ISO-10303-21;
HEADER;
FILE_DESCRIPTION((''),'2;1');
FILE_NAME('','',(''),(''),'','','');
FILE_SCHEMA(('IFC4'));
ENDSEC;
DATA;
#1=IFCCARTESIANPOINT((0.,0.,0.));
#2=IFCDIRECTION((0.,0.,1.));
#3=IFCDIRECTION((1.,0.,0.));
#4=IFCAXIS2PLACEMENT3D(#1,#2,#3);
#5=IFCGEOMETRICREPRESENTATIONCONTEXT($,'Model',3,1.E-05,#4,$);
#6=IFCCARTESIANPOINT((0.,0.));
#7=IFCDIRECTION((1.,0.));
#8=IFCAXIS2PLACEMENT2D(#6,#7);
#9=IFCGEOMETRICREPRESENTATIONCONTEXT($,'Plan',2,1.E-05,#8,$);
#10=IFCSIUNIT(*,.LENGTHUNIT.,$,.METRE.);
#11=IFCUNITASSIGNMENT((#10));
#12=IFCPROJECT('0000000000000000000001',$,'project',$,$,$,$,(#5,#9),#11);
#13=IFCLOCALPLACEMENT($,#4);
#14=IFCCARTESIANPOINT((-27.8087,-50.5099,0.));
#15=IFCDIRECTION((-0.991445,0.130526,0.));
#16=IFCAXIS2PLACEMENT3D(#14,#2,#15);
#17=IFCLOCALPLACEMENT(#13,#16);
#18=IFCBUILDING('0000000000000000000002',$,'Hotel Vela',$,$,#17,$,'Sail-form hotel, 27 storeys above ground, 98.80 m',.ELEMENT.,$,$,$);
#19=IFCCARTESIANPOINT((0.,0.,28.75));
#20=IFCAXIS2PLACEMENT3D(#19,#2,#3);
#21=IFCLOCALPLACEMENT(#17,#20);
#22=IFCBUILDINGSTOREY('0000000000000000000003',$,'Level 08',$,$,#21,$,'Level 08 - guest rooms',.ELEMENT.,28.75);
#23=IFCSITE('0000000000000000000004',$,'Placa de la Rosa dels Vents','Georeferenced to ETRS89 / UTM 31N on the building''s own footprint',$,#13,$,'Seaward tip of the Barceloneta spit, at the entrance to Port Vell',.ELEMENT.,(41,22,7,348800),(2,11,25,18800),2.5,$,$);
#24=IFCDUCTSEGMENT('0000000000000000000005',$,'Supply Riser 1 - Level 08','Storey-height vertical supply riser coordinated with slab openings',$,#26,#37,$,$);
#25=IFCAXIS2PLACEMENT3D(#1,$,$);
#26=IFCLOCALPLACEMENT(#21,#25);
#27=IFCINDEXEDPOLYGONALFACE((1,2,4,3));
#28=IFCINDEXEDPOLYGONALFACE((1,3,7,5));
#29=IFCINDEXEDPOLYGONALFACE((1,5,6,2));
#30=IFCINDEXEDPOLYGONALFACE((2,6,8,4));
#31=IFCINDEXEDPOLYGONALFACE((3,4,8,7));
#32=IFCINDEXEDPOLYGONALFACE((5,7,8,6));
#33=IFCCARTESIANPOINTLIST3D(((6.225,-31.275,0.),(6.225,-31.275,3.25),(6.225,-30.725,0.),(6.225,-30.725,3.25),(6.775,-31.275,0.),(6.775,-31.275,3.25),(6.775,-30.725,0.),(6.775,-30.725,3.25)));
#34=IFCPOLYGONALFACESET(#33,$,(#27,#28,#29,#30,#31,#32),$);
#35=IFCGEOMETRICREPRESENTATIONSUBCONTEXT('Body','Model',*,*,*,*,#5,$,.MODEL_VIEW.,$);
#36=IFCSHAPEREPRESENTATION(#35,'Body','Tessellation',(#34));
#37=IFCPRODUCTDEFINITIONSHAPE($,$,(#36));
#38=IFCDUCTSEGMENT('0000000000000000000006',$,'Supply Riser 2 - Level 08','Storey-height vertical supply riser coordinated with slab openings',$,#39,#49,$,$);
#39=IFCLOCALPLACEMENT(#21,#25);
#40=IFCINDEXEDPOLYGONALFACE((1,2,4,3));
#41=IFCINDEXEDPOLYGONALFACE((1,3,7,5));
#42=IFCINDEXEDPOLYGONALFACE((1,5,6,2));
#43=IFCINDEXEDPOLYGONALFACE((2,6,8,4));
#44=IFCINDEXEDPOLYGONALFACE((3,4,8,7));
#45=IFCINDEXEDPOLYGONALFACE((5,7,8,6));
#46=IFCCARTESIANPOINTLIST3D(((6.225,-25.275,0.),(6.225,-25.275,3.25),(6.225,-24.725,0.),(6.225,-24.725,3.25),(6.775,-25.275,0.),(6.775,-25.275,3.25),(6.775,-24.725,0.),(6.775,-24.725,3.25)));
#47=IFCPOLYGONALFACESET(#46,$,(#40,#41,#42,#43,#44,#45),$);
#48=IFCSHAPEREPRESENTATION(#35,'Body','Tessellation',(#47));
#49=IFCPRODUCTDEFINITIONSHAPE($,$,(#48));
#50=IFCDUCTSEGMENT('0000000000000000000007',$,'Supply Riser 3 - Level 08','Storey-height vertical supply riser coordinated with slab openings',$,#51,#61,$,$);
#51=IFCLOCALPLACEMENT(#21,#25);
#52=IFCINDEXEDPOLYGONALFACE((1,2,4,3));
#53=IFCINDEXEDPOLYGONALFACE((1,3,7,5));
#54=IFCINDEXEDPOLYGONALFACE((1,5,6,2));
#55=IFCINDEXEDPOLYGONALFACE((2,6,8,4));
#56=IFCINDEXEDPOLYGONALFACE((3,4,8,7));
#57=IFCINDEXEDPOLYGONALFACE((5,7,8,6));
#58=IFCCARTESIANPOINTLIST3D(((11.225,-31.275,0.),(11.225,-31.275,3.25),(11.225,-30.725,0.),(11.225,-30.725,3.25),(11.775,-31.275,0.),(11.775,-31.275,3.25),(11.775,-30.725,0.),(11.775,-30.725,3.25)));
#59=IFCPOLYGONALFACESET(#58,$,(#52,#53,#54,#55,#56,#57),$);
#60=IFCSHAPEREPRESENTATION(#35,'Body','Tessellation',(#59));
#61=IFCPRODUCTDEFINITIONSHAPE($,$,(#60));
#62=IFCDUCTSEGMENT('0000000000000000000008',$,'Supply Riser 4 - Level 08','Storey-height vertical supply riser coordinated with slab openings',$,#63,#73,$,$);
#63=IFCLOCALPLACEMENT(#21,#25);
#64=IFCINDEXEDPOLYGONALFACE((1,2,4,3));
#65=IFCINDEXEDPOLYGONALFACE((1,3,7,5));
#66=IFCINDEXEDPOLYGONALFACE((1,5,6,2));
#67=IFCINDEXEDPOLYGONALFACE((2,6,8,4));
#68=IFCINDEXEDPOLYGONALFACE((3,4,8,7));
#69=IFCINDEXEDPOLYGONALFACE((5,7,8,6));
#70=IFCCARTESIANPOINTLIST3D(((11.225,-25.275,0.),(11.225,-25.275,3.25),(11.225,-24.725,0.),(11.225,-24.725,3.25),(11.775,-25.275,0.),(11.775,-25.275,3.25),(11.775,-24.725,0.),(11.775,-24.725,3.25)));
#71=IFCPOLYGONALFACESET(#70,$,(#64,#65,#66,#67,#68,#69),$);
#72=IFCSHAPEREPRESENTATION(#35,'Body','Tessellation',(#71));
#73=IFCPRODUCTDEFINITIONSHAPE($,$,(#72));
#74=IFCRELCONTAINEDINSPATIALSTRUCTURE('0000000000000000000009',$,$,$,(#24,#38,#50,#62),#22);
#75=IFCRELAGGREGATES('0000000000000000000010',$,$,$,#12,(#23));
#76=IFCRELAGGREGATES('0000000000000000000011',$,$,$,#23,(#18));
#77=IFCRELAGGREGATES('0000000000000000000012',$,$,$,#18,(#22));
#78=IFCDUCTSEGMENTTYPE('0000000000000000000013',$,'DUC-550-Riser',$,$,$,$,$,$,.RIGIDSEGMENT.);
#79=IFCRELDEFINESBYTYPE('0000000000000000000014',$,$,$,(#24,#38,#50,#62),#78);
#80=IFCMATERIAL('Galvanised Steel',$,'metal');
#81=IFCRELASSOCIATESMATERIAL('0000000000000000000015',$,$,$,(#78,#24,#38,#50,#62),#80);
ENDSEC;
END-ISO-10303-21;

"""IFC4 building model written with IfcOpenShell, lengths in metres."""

from ifc_helpers import new_model, si_unit, frame, origin_with_axes, origin_2d_with_axis, place, context, subcontext, project, spatial, line, indexed_curve, outline, extrude, material, type_object, element, save


model = new_model("IFC4")

# Units and contexts
model_context = context("Model", 3, precision=1e-05, world=origin_with_axes())
plan_context = context("Plan", 2, precision=1e-05, world=origin_2d_with_axis())
body_context = subcontext(model_context, "Body", "Model", "MODEL_VIEW")
ifc_project = project(units=[si_unit("LENGTHUNIT", "METRE")], contexts=[model_context, plan_context])

# Site, building, storey
site_placement = place(None, origin_with_axes())
site = spatial("IfcSite", under=ifc_project, at=site_placement, Name="Placa de la Rosa dels Vents", Description="Georeferenced to ETRS89 / UTM 31N on the building's own footprint", LongName="Seaward tip of the Barceloneta spit, at the entrance to Port Vell", CompositionType="ELEMENT", RefLatitude=(41, 22, 7, 348800), RefLongitude=(2, 11, 25, 18800), RefElevation=2.5)
building_placement = place(site_placement, frame((-27.8087, -50.5099, 0.0), z_axis=(0.0, 0.0, 1.0), x_axis=(-0.991445, 0.130526, 0.0)))
building = spatial("IfcBuilding", under=site, at=building_placement, Name="Hotel Vela", LongName="Sail-form hotel, 27 storeys above ground, 98.80 m", CompositionType="ELEMENT")
storey_placement = place(building_placement, frame((0.0, 0.0, 28.75), z_axis=(0.0, 0.0, 1.0), x_axis=(1.0, 0.0, 0.0)))
storey = spatial("IfcBuildingStorey", under=building, at=storey_placement, Name="Level 08", LongName="Level 08 - guest rooms", CompositionType="ELEMENT", Elevation=28.75)

# Duct segments
ifc_material = material(Name="Galvanised Steel", Category="metal")
duct_segment_type = type_object("IfcDuctSegmentType", Name="DUC-550-Riser", PredefinedType="RIGIDSEGMENT", material=ifc_material)
for number, where, z_axis, x_axis, name in (
    (1, (6.225, -31.275, 0.0), (0.0, 0.0, 1.0), (1.0, 0.0, 0.0), "Supply Riser 1 - Level 08"),
    (2, (6.225, -25.275, 0.0), (0.0, 0.0, 1.0), (1.0, 0.0, 0.0), "Supply Riser 2 - Level 08"),
    (3, (11.225, -31.275, 0.0), (0.0, 0.0, 1.0), (1.0, 0.0, 0.0), "Supply Riser 3 - Level 08"),
    (4, (11.225, -25.275, 0.0), (0.0, 0.0, 1.0), (1.0, 0.0, 0.0), "Supply Riser 4 - Level 08"),
):
    element("IfcDuctSegment", number, at=place(storey_placement, frame(where, z_axis=z_axis, x_axis=x_axis)), inside=storey, type_object=duct_segment_type, material=ifc_material, Name=name, Description="Storey-height vertical supply riser coordinated with slab openings", context=body_context, shape_type="SweptSolid", body=[
        extrude(outline(indexed_curve([(0.0, 0.0), (0.55, 0.0), (0.55, 0.55), (0.0, 0.55)], segments=[line(1, 2, 3, 4, 1)])), origin_with_axes(), (0.0, 0.0, 1.0), 3.25),
    ])

save(model, "model.ifc")
